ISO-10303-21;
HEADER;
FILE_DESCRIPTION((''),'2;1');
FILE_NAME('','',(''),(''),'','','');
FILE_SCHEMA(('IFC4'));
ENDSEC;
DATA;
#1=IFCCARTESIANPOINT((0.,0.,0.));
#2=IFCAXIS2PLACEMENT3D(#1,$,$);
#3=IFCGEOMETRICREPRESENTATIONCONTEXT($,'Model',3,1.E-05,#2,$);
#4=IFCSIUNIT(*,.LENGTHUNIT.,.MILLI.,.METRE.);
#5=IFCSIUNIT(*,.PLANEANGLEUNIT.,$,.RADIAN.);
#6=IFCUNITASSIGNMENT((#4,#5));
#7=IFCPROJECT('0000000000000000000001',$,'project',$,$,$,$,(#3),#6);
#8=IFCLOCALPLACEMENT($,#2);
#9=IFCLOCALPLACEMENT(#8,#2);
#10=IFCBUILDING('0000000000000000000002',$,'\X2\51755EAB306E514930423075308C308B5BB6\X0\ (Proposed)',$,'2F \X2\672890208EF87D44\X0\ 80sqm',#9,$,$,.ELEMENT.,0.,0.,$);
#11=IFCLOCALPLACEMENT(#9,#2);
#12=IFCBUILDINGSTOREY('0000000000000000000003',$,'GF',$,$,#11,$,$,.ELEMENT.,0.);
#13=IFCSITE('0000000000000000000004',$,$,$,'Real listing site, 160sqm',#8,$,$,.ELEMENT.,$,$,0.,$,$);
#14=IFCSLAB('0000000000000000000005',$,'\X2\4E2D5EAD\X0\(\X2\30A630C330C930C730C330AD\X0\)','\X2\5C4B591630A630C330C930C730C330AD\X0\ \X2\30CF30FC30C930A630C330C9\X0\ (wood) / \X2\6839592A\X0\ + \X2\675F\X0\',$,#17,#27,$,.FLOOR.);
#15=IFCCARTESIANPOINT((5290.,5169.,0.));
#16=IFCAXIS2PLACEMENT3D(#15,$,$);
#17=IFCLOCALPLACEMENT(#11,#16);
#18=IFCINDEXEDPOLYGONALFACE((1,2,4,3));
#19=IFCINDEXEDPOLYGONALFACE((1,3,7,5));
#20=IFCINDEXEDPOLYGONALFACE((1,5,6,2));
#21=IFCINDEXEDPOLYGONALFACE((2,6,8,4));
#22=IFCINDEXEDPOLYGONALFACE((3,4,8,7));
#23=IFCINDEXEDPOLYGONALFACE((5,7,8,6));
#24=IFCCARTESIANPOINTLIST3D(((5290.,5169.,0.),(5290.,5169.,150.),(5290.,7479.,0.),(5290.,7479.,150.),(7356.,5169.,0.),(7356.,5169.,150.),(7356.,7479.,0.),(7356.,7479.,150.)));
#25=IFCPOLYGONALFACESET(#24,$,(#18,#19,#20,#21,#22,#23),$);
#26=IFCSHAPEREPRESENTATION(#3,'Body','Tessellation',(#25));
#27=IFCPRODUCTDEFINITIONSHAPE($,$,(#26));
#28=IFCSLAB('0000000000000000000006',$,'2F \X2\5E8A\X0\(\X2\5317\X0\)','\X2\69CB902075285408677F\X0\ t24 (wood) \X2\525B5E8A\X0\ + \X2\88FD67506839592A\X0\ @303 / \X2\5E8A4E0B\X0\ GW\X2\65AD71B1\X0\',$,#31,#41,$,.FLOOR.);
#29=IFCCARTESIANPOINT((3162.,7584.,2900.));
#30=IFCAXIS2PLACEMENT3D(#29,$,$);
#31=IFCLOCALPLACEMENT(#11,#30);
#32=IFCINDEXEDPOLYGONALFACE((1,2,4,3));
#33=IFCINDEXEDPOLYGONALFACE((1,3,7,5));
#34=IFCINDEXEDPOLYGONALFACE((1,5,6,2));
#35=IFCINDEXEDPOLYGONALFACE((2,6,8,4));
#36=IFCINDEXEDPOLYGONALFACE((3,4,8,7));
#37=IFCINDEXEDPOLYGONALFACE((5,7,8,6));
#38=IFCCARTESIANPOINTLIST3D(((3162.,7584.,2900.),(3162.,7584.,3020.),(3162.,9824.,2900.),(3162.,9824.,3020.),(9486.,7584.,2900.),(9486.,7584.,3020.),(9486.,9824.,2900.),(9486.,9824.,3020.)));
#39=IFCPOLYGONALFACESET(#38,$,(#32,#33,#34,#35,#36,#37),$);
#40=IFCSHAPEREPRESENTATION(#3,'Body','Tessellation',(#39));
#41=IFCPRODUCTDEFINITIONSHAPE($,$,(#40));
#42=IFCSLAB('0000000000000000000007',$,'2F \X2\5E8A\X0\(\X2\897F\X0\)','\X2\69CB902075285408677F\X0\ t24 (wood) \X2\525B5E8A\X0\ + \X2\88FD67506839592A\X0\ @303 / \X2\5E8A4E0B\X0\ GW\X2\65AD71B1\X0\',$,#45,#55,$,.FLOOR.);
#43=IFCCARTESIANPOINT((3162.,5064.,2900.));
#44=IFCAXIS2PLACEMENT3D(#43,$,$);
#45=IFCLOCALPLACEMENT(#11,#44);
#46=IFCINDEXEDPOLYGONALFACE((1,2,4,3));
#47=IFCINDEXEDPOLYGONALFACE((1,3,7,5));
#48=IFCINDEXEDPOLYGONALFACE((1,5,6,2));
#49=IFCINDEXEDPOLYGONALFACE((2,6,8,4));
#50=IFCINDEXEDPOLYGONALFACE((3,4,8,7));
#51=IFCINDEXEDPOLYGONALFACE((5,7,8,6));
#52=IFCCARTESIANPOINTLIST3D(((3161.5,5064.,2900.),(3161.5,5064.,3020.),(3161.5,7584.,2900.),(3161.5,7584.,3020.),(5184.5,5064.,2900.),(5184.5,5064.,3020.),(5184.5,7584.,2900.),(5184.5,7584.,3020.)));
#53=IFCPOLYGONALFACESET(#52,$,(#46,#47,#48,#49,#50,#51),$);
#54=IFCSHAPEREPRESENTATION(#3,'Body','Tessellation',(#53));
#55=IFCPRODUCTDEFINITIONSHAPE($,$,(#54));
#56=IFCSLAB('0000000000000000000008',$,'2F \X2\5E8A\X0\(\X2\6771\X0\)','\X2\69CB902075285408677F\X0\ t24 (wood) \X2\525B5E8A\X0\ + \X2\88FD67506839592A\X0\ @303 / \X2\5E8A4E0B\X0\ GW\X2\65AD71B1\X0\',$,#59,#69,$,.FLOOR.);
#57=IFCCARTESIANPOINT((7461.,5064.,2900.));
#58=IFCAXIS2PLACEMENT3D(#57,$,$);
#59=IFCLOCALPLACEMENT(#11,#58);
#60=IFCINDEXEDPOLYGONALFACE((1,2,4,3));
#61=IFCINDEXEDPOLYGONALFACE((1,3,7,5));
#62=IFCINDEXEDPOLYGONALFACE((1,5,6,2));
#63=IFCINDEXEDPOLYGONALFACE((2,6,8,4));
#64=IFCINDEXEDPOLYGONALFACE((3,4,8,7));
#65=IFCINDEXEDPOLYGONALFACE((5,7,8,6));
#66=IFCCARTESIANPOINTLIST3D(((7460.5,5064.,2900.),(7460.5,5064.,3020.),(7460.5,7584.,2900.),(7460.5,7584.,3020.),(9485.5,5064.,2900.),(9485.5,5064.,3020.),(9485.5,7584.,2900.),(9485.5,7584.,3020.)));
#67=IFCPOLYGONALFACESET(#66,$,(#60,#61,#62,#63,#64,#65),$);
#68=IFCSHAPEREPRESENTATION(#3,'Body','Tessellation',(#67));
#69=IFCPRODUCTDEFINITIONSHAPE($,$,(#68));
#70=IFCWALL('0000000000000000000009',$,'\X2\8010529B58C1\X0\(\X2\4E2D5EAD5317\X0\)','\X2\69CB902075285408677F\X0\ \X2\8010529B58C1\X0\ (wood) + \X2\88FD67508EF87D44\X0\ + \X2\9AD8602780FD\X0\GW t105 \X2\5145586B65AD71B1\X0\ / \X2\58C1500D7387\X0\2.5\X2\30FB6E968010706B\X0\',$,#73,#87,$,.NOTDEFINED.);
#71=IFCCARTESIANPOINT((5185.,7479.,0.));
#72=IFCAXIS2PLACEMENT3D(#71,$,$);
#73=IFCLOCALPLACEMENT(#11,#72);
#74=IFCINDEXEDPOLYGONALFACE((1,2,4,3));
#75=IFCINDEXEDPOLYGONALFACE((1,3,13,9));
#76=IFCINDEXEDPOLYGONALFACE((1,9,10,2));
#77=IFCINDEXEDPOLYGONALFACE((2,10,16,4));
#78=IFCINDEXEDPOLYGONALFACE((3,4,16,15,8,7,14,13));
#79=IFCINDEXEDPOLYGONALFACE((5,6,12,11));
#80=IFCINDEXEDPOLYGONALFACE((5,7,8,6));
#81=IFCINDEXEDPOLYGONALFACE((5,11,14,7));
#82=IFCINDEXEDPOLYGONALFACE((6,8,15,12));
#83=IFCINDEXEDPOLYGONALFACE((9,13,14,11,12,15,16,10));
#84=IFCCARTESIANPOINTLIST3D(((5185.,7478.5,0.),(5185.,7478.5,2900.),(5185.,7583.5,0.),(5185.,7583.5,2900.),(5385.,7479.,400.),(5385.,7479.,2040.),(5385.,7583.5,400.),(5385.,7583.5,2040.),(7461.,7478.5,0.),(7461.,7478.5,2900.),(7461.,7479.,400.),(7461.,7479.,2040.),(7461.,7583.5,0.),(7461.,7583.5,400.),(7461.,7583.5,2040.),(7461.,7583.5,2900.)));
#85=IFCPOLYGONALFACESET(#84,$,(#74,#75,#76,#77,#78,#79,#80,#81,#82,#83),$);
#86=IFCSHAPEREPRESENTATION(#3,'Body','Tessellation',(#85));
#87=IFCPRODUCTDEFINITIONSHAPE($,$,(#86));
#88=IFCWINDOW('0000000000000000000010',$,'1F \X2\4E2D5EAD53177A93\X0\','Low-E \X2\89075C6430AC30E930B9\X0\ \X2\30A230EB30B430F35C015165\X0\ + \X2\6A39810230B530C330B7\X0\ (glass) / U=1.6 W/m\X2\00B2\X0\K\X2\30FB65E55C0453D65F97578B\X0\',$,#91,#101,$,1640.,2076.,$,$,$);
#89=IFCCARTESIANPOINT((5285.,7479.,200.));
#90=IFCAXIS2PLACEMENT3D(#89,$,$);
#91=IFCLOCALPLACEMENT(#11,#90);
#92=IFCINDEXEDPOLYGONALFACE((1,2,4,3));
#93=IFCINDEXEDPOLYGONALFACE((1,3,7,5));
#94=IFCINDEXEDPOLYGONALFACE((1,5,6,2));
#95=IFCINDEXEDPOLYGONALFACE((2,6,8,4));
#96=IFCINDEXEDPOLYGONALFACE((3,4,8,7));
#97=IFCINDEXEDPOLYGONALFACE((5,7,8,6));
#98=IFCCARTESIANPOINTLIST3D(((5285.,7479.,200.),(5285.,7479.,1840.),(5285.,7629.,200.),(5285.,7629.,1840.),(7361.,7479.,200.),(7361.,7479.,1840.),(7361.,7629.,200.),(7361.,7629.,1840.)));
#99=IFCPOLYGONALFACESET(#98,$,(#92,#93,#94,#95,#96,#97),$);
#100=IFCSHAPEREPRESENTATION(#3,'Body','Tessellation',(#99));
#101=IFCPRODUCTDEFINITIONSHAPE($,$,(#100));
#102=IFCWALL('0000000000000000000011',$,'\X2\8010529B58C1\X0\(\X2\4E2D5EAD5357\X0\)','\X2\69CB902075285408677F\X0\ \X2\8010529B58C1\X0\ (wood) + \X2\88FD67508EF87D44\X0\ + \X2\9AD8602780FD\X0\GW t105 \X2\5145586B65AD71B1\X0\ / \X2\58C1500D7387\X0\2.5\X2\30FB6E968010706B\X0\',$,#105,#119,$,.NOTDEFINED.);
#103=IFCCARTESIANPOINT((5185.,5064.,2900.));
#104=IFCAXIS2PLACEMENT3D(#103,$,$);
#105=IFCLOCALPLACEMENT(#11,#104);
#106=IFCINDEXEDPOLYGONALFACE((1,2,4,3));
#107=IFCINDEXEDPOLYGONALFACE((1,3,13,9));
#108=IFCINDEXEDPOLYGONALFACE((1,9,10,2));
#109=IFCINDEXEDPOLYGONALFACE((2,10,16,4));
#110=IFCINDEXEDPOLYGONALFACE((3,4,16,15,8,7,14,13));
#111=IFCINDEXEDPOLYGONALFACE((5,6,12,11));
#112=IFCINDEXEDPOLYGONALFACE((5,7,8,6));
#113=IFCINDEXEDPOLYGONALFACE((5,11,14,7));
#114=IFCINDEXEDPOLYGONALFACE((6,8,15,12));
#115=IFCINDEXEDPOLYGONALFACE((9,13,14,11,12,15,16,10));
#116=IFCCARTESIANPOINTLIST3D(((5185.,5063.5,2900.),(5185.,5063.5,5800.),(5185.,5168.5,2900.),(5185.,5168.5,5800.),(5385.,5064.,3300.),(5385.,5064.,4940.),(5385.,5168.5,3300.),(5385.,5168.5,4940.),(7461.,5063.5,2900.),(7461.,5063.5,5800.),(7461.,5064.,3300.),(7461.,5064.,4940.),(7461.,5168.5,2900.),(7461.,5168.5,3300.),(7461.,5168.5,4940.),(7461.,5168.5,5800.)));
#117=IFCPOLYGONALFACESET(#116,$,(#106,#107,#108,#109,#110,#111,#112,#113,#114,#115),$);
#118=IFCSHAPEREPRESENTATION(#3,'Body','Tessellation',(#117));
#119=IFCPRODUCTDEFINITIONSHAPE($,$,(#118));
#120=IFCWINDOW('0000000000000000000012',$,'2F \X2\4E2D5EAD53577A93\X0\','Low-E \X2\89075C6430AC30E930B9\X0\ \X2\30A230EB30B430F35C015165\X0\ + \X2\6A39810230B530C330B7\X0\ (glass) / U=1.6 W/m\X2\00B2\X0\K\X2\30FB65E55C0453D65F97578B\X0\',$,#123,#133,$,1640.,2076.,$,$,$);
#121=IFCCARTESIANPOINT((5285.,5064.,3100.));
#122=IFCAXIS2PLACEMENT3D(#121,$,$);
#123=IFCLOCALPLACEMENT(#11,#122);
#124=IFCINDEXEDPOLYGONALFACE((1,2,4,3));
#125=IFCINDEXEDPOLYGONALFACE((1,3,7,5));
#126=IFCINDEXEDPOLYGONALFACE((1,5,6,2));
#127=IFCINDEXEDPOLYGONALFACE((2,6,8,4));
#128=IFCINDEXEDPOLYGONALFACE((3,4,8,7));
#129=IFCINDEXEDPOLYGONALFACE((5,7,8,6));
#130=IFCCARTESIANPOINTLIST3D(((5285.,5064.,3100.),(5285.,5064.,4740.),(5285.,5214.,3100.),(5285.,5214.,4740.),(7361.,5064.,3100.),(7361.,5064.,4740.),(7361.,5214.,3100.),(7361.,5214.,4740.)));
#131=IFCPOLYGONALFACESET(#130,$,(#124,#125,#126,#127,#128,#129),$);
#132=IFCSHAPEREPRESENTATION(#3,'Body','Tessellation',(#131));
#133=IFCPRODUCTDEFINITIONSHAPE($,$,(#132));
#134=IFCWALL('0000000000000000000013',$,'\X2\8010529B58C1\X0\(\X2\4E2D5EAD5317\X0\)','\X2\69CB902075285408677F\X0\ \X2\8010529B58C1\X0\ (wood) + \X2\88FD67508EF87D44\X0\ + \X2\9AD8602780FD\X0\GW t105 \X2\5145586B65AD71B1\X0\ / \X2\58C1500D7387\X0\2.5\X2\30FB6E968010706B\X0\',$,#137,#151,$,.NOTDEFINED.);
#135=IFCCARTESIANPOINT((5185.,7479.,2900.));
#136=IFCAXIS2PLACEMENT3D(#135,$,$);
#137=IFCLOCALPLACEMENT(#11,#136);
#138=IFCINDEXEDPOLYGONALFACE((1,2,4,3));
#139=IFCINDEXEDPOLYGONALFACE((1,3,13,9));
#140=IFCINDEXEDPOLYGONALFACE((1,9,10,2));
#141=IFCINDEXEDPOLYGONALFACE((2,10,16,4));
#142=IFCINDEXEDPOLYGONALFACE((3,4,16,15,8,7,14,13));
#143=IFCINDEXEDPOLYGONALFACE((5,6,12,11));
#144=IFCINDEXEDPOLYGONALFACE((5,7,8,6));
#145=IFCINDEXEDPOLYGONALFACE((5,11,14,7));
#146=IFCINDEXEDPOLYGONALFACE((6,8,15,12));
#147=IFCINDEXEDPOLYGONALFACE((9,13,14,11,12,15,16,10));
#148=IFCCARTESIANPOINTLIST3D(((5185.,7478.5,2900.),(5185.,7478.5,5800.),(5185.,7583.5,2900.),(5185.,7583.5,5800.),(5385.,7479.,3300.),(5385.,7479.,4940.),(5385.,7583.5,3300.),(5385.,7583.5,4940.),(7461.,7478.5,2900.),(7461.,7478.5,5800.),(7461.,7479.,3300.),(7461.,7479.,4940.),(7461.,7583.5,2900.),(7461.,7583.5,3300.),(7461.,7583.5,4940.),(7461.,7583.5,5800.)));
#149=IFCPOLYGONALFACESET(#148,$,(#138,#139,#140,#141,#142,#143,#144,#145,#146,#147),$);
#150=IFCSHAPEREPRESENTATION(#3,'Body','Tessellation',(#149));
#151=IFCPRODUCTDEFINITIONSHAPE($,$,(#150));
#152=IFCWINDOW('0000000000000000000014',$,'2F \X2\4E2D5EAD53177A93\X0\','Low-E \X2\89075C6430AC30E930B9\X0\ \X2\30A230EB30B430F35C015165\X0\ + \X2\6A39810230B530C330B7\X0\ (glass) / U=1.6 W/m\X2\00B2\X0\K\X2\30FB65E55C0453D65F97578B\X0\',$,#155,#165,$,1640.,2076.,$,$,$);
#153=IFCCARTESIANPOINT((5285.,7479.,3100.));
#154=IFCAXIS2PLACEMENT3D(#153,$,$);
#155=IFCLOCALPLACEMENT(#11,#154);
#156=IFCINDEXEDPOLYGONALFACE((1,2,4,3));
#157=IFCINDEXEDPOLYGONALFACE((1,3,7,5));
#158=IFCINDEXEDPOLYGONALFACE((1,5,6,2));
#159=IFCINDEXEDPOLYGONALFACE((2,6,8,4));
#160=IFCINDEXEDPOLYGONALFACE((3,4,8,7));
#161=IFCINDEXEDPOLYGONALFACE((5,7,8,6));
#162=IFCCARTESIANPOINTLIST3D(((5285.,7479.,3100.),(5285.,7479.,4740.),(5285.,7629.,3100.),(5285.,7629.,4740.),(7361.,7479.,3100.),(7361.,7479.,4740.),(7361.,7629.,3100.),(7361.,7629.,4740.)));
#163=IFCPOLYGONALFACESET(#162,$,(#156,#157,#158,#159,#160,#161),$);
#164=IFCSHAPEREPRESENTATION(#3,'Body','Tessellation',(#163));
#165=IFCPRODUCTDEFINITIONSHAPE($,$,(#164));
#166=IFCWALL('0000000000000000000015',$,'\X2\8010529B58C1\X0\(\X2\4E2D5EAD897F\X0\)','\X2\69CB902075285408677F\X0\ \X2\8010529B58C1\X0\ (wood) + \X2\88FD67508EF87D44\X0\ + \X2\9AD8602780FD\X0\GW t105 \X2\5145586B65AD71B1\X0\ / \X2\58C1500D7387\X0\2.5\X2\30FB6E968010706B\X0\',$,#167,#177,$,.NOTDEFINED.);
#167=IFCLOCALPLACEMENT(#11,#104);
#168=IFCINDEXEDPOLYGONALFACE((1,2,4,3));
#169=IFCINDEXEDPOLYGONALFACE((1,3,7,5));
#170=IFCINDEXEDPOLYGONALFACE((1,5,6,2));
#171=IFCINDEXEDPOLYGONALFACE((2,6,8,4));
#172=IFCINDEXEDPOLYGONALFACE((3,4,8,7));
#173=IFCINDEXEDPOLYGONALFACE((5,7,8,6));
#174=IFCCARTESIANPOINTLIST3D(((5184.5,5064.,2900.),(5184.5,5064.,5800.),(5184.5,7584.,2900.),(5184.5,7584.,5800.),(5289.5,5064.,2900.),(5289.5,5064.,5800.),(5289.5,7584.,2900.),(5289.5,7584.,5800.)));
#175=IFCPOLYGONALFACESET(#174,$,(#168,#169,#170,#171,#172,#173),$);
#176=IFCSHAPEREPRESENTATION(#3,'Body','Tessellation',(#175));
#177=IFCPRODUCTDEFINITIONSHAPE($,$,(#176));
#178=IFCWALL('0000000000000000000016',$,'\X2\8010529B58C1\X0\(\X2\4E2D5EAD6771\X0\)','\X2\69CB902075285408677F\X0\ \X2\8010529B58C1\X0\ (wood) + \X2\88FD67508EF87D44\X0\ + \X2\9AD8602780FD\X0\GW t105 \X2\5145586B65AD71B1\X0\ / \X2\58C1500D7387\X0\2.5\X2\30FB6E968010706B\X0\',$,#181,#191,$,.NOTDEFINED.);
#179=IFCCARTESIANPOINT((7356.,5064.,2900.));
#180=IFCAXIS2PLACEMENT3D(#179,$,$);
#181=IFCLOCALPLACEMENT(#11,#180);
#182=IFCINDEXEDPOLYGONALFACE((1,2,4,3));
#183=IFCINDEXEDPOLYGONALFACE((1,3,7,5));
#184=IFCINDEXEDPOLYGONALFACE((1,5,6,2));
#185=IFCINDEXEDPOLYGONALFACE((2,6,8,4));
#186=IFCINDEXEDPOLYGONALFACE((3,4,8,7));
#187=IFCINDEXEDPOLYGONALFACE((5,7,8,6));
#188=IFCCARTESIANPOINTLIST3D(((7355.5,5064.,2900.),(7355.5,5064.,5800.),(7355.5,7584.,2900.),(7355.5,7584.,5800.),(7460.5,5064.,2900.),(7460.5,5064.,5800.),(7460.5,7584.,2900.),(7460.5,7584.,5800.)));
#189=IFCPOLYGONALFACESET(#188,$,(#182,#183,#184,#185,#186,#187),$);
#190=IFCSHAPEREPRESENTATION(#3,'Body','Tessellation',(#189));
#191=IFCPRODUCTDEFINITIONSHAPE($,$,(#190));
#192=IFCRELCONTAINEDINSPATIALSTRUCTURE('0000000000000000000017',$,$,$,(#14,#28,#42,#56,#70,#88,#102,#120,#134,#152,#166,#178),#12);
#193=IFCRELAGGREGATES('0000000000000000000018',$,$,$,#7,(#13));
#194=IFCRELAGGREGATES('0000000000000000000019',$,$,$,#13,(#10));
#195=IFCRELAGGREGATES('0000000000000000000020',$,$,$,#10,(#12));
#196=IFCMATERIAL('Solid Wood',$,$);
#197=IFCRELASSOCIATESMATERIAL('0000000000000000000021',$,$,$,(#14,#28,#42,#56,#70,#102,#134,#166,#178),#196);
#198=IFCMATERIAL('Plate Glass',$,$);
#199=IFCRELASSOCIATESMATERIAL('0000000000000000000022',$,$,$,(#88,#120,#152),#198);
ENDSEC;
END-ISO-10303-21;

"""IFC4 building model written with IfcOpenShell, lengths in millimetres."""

from ifc_helpers import new_model, si_unit, frame, frame_2d, origin, place, context, project, spatial, rectangle, extrude, material, element, fill, save


model = new_model("IFC4")

# Units and contexts
model_context = context("Model", 3, precision=1e-05, world=origin())
ifc_project = project(units=[si_unit("LENGTHUNIT", "METRE", prefix="MILLI"), si_unit("PLANEANGLEUNIT", "RADIAN")], contexts=[model_context])

# Site, building, storey
site_placement = place(None, origin())
site = spatial("IfcSite", under=ifc_project, at=site_placement, ObjectType="Real listing site, 160sqm", CompositionType="ELEMENT", RefElevation=0.0)
building_placement = place(site_placement, origin())
building = spatial("IfcBuilding", under=site, at=building_placement, Name="兵庫の光あふれる家 (Proposed)", ObjectType="2F 木造軸組 80sqm", CompositionType="ELEMENT", ElevationOfRefHeight=0.0, ElevationOfTerrain=0.0)
storey_placement = place(building_placement, origin())
storey = spatial("IfcBuildingStorey", under=building, at=storey_placement, Name="GF", CompositionType="ELEMENT", Elevation=0.0)

# Slabs
ifc_material_1 = material(Name="Solid Wood")
slab_1_placement = place(storey_placement, frame((5290.0, 5169.0, 0.0)))
element("IfcSlab", 1, at=slab_1_placement, inside=storey, material=ifc_material_1, Name="中庭(ウッドデッキ)", Description="屋外ウッドデッキ ハードウッド (wood) / 根太 + 束", PredefinedType="FLOOR", context=model_context, shape_type="SweptSolid", body=[
    extrude(rectangle(XDim=2066.0, YDim=2310.0, at=frame_2d((1033.0, 1155.0))), frame((5290.0, 5169.0, 0.0)), (0.0, 0.0, 1.0), 150.0),
])
slab_2_placement = place(storey_placement, frame((3162.0, 7584.0, 2900.0)))
element("IfcSlab", 2, at=slab_2_placement, inside=storey, material=ifc_material_1, Name="2F 床(北)", Description="構造用合板 t24 (wood) 剛床 + 製材根太 @303 / 床下 GW断熱", PredefinedType="FLOOR", context=model_context, shape_type="SweptSolid", body=[
    extrude(rectangle(XDim=6324.0, YDim=2240.0, at=frame_2d((3162.0, 1120.0))), frame((3162.0, 7584.0, 2900.0)), (0.0, 0.0, 1.0), 120.0),
])
slab_3_placement = place(storey_placement, frame((3162.0, 5064.0, 2900.0)))
element("IfcSlab", 3, at=slab_3_placement, inside=storey, material=ifc_material_1, Name="2F 床(西)", Description="構造用合板 t24 (wood) 剛床 + 製材根太 @303 / 床下 GW断熱", PredefinedType="FLOOR", context=model_context, shape_type="SweptSolid", body=[
    extrude(rectangle(XDim=2023.0, YDim=2520.0, at=frame_2d((1011.0, 1260.0))), frame((3162.0, 5064.0, 2900.0)), (0.0, 0.0, 1.0), 120.0),
])
slab_4_placement = place(storey_placement, frame((7461.0, 5064.0, 2900.0)))
element("IfcSlab", 4, at=slab_4_placement, inside=storey, material=ifc_material_1, Name="2F 床(東)", Description="構造用合板 t24 (wood) 剛床 + 製材根太 @303 / 床下 GW断熱", PredefinedType="FLOOR", context=model_context, shape_type="SweptSolid", body=[
    extrude(rectangle(XDim=2025.0, YDim=2520.0, at=frame_2d((1012.0, 1260.0))), frame((7461.0, 5064.0, 2900.0)), (0.0, 0.0, 1.0), 120.0),
])

# Wall, opening, window
wall_1_placement = place(storey_placement, frame((5185.0, 7479.0, 0.0)))
wall_1 = element("IfcWall", 5, at=wall_1_placement, inside=storey, material=ifc_material_1, Name="耐力壁(中庭北)", Description="構造用合板 耐力壁 (wood) + 製材軸組 + 高性能GW t105 充填断熱 / 壁倍率2.5・準耐火", PredefinedType="NOTDEFINED", context=model_context, shape_type="SweptSolid", body=[
    extrude(rectangle(XDim=2276.0, YDim=105.0, at=frame_2d((1138.0, 52.0))), frame((5185.0, 7479.0, 0.0)), (0.0, 0.0, 1.0), 2900.0),
])
opening_1_placement = place(storey_placement, frame((5285.0, 7479.0, 200.0)))
opening_1 = element("IfcOpeningElement", 6, at=opening_1_placement, cuts=wall_1, PredefinedType="NOTDEFINED", context=model_context, shape_type="SweptSolid", body=[
    extrude(rectangle(XDim=2076.0, YDim=150.0, at=frame_2d((1038.0, 75.0))), frame((5285.0, 7479.0, 200.0)), (0.0, 0.0, 1.0), 1640.0),
])
ifc_material_2 = material(Name="Plate Glass")
window_1_placement = place(storey_placement, frame((5285.0, 7479.0, 200.0)))
window_1 = element("IfcWindow", 7, at=window_1_placement, inside=storey, material=ifc_material_2, Name="1F 中庭北窓", Description="Low-E 複層ガラス アルゴン封入 + 樹脂サッシ (glass) / U=1.6 W/m²K・日射取得型", OverallHeight=1640.0, OverallWidth=2076.0, context=model_context, shape_type="SweptSolid", body=[
    extrude(rectangle(XDim=2076.0, YDim=150.0, at=frame_2d((1038.0, 75.0))), frame((5285.0, 7479.0, 200.0)), (0.0, 0.0, 1.0), 1640.0),
])
fill(opening_1, window_1)

# Walls, openings, windows
wall_2_placement = place(storey_placement, frame((5185.0, 5064.0, 2900.0)))
wall_2 = element("IfcWall", 8, at=wall_2_placement, inside=storey, material=ifc_material_1, Name="耐力壁(中庭南)", Description="構造用合板 耐力壁 (wood) + 製材軸組 + 高性能GW t105 充填断熱 / 壁倍率2.5・準耐火", PredefinedType="NOTDEFINED", context=model_context, shape_type="SweptSolid", body=[
    extrude(rectangle(XDim=2276.0, YDim=105.0, at=frame_2d((1138.0, 52.0))), frame((5185.0, 5064.0, 2900.0)), (0.0, 0.0, 1.0), 2900.0),
])
opening_2_placement = place(storey_placement, frame((5285.0, 5064.0, 3100.0)))
opening_2 = element("IfcOpeningElement", 9, at=opening_2_placement, cuts=wall_2, PredefinedType="NOTDEFINED", context=model_context, shape_type="SweptSolid", body=[
    extrude(rectangle(XDim=2076.0, YDim=150.0, at=frame_2d((1038.0, 75.0))), frame((5285.0, 5064.0, 3100.0)), (0.0, 0.0, 1.0), 1640.0),
])
window_2_placement = place(storey_placement, frame((5285.0, 5064.0, 3100.0)))
window_2 = element("IfcWindow", 10, at=window_2_placement, inside=storey, material=ifc_material_2, Name="2F 中庭南窓", Description="Low-E 複層ガラス アルゴン封入 + 樹脂サッシ (glass) / U=1.6 W/m²K・日射取得型", OverallHeight=1640.0, OverallWidth=2076.0, context=model_context, shape_type="SweptSolid", body=[
    extrude(rectangle(XDim=2076.0, YDim=150.0, at=frame_2d((1038.0, 75.0))), frame((5285.0, 5064.0, 3100.0)), (0.0, 0.0, 1.0), 1640.0),
])
fill(opening_2, window_2)
wall_3_placement = place(storey_placement, frame((5185.0, 7479.0, 2900.0)))
wall_3 = element("IfcWall", 11, at=wall_3_placement, inside=storey, material=ifc_material_1, Name="耐力壁(中庭北)", Description="構造用合板 耐力壁 (wood) + 製材軸組 + 高性能GW t105 充填断熱 / 壁倍率2.5・準耐火", PredefinedType="NOTDEFINED", context=model_context, shape_type="SweptSolid", body=[
    extrude(rectangle(XDim=2276.0, YDim=105.0, at=frame_2d((1138.0, 52.0))), frame((5185.0, 7479.0, 2900.0)), (0.0, 0.0, 1.0), 2900.0),
])
opening_3_placement = place(storey_placement, frame((5285.0, 7479.0, 3100.0)))
opening_3 = element("IfcOpeningElement", 12, at=opening_3_placement, cuts=wall_3, PredefinedType="NOTDEFINED", context=model_context, shape_type="SweptSolid", body=[
    extrude(rectangle(XDim=2076.0, YDim=150.0, at=frame_2d((1038.0, 75.0))), frame((5285.0, 7479.0, 3100.0)), (0.0, 0.0, 1.0), 1640.0),
])
window_3_placement = place(storey_placement, frame((5285.0, 7479.0, 3100.0)))
window_3 = element("IfcWindow", 13, at=window_3_placement, inside=storey, material=ifc_material_2, Name="2F 中庭北窓", Description="Low-E 複層ガラス アルゴン封入 + 樹脂サッシ (glass) / U=1.6 W/m²K・日射取得型", OverallHeight=1640.0, OverallWidth=2076.0, context=model_context, shape_type="SweptSolid", body=[
    extrude(rectangle(XDim=2076.0, YDim=150.0, at=frame_2d((1038.0, 75.0))), frame((5285.0, 7479.0, 3100.0)), (0.0, 0.0, 1.0), 1640.0),
])
fill(opening_3, window_3)

# Walls
wall_4_placement = place(storey_placement, frame((5185.0, 5064.0, 2900.0)))
element("IfcWall", 14, at=wall_4_placement, inside=storey, material=ifc_material_1, Name="耐力壁(中庭西)", Description="構造用合板 耐力壁 (wood) + 製材軸組 + 高性能GW t105 充填断熱 / 壁倍率2.5・準耐火", PredefinedType="NOTDEFINED", context=model_context, shape_type="SweptSolid", body=[
    extrude(rectangle(XDim=105.0, YDim=2520.0, at=frame_2d((52.0, 1260.0))), frame((5185.0, 5064.0, 2900.0)), (0.0, 0.0, 1.0), 2900.0),
])
wall_5_placement = place(storey_placement, frame((7356.0, 5064.0, 2900.0)))
element("IfcWall", 15, at=wall_5_placement, inside=storey, material=ifc_material_1, Name="耐力壁(中庭東)", Description="構造用合板 耐力壁 (wood) + 製材軸組 + 高性能GW t105 充填断熱 / 壁倍率2.5・準耐火", PredefinedType="NOTDEFINED", context=model_context, shape_type="SweptSolid", body=[
    extrude(rectangle(XDim=105.0, YDim=2520.0, at=frame_2d((52.0, 1260.0))), frame((7356.0, 5064.0, 2900.0)), (0.0, 0.0, 1.0), 2900.0),
])

save(model, "model.ifc")
